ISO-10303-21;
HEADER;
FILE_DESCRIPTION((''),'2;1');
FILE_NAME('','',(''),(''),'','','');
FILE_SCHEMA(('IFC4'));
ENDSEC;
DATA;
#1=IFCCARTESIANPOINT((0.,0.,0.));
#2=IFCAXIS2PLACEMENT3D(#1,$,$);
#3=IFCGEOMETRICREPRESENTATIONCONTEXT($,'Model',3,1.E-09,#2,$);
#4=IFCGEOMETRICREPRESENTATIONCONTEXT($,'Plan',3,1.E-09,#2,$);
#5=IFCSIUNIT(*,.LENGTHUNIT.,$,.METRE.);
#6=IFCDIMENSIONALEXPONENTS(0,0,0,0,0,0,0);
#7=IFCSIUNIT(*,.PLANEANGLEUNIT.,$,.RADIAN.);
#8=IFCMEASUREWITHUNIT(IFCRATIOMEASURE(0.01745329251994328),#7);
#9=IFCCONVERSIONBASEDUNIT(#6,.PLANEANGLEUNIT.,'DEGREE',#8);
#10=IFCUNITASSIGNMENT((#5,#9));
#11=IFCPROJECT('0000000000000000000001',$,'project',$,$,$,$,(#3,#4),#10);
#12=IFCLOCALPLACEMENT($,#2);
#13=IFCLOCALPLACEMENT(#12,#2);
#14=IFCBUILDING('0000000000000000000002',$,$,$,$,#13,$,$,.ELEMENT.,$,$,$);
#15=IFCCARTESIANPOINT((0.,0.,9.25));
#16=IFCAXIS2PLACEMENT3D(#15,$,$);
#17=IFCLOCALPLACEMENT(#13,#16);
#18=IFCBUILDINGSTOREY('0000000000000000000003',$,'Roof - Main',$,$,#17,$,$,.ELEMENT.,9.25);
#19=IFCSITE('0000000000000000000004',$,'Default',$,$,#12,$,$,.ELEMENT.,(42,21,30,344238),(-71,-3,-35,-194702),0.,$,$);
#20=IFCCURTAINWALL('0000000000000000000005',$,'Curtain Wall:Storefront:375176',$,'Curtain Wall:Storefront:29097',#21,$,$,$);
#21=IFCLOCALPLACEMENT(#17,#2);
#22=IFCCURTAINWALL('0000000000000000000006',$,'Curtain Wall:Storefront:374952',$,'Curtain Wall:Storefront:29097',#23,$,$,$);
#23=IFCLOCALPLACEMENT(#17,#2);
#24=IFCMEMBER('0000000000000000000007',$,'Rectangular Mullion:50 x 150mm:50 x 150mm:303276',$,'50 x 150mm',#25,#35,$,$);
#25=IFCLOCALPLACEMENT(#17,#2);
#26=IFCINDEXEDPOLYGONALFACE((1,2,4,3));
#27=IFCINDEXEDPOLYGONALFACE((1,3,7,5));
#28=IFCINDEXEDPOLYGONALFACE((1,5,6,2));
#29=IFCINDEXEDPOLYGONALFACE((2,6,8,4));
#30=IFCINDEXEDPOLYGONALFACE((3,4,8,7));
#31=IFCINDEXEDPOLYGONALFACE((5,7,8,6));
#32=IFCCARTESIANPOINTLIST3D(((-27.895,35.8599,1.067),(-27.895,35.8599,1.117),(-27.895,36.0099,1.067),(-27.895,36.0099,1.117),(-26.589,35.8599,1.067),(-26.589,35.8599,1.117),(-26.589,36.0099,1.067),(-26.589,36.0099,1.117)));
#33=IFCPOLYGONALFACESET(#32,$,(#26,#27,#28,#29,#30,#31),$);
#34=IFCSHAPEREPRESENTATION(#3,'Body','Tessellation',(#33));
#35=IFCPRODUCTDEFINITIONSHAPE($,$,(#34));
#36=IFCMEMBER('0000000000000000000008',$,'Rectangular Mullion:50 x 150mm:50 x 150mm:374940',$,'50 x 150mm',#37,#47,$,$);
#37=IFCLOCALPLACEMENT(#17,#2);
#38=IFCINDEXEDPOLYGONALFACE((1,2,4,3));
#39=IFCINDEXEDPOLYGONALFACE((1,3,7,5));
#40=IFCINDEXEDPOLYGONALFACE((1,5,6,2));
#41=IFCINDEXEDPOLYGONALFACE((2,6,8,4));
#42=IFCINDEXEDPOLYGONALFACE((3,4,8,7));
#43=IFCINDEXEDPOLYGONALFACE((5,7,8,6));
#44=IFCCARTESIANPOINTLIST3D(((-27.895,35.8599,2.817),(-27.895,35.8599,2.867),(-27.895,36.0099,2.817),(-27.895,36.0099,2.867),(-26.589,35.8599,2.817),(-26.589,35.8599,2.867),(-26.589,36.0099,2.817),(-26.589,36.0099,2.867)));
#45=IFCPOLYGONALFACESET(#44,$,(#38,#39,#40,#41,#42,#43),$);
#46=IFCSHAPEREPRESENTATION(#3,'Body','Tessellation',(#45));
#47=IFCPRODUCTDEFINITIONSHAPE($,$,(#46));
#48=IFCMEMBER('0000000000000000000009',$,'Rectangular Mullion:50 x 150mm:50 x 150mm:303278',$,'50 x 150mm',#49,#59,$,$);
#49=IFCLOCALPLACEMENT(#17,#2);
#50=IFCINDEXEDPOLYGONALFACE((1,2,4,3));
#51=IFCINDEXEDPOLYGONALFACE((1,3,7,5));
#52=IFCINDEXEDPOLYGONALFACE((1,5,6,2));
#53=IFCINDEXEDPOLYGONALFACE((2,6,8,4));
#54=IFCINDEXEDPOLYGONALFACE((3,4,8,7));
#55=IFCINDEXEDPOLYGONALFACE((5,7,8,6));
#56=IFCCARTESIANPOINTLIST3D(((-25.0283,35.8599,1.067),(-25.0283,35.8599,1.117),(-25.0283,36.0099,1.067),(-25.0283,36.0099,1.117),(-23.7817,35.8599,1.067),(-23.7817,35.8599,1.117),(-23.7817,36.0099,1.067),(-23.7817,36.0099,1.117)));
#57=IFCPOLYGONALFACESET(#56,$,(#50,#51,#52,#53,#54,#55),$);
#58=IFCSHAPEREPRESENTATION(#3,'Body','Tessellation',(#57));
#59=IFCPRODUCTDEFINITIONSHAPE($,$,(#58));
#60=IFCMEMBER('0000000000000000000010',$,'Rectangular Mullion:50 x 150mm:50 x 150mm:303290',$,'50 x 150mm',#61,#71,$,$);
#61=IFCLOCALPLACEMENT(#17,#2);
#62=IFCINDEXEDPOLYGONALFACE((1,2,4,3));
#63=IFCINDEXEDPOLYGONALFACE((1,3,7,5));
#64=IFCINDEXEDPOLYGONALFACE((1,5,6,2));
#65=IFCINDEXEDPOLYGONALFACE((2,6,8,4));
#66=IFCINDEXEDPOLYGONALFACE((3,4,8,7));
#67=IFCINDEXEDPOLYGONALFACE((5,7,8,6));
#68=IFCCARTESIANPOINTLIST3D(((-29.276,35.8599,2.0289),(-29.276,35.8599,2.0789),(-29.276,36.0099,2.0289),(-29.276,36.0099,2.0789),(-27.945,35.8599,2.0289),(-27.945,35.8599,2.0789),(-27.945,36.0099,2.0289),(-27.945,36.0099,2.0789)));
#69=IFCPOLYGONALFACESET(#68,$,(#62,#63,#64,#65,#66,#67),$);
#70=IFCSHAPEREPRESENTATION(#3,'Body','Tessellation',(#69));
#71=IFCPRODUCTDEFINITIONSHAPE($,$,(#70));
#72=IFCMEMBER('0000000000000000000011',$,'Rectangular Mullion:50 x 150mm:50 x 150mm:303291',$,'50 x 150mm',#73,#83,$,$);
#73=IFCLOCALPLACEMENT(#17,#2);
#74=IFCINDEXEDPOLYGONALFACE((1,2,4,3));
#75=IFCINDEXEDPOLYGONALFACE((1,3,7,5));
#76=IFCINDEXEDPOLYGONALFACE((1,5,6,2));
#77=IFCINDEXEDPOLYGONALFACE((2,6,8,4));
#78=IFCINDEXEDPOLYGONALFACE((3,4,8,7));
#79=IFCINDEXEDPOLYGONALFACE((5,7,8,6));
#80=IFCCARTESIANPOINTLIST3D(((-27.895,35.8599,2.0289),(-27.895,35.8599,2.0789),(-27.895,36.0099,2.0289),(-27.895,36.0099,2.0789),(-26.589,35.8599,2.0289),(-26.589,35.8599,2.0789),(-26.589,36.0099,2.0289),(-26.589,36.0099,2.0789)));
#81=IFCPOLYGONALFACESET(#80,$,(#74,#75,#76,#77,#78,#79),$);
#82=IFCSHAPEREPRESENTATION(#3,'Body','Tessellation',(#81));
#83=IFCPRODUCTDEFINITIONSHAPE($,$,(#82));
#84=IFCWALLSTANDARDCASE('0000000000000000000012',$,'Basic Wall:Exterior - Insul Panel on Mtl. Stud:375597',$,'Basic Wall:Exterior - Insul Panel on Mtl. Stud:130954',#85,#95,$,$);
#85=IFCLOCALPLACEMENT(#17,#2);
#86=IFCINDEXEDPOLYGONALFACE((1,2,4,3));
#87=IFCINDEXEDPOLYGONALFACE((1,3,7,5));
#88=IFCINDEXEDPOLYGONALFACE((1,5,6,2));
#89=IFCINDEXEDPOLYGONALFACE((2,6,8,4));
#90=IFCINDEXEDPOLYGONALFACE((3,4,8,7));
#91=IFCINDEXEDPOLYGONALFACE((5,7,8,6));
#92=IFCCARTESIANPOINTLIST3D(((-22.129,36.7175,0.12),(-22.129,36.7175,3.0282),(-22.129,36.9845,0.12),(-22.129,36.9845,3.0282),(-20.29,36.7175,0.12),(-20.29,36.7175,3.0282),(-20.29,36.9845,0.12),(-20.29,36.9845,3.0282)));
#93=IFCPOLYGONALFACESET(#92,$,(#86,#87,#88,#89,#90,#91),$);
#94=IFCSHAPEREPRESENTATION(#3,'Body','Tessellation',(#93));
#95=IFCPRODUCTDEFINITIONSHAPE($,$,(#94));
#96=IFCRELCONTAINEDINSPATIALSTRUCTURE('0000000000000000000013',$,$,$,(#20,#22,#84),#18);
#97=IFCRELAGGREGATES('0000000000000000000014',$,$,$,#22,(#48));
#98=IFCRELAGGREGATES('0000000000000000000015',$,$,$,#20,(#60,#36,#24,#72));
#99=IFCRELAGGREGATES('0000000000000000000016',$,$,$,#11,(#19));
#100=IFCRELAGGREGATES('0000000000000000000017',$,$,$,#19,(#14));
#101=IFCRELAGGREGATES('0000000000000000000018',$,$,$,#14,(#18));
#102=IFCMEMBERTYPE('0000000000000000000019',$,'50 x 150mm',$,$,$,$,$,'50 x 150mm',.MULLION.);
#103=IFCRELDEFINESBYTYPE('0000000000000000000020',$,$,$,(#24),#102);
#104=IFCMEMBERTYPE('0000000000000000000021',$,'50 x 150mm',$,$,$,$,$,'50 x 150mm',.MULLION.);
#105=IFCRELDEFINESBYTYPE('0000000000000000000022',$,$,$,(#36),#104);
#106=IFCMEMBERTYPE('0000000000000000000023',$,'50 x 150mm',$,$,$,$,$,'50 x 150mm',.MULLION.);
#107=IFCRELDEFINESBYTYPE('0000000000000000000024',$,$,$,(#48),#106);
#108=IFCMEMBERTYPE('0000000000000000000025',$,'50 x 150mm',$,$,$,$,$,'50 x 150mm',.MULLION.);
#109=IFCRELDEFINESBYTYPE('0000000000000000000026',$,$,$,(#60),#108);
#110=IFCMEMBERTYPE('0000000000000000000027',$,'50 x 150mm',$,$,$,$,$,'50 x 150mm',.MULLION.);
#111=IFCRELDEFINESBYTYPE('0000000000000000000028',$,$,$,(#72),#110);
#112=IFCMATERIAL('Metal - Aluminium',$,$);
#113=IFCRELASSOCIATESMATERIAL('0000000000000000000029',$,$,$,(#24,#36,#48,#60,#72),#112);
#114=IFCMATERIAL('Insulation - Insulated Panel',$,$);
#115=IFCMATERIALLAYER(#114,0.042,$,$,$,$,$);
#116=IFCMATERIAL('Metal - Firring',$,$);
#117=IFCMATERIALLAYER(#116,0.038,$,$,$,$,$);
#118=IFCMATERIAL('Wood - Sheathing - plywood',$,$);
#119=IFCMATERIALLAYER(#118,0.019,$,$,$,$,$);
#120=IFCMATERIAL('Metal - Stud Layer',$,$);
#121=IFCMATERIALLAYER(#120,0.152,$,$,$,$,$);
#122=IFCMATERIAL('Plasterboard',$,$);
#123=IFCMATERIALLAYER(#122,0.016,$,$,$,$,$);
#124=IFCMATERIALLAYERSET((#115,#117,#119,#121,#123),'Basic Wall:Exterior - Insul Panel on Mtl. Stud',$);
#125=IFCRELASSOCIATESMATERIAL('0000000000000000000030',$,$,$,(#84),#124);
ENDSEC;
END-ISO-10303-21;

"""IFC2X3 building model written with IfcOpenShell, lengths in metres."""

from ifc_helpers import new_model, entity, si_unit, converted_unit, frame, frame_2d, origin, origin_2d_with_axis, place, context, project, spatial, rectangle, extrude, source, transform, mapped, material, layer, layer_set, layer_usage, type_object, type_shapes, element, aggregate, save


model = new_model("IFC2X3")

# Units and contexts
model_context = context("Model", 3, precision=1e-09, world=origin())
plan_context = context("Plan", 3, precision=1e-09, world=origin())
ifc_project = project(units=[si_unit("LENGTHUNIT", "METRE"), converted_unit("PLANEANGLEUNIT", "DEGREE", entity("IfcRatioMeasure", 0.01745329251994328), si_unit("PLANEANGLEUNIT", "RADIAN"), dimensions=[0, 0, 0, 0, 0, 0, 0])], contexts=[model_context, plan_context])

# Site, building, storey
site_placement = place(None, origin())
site = spatial("IfcSite", under=ifc_project, at=site_placement, Name="Default", CompositionType="ELEMENT", RefLatitude=(42, 21, 30, 344238), RefLongitude=(-71, -3, -35, -194702), RefElevation=0.0)
building_placement = place(site_placement, origin())
building = spatial("IfcBuilding", under=site, at=building_placement, CompositionType="ELEMENT")
storey_placement = place(building_placement, frame((0.0, 0.0, 9.25)))
storey = spatial("IfcBuildingStorey", under=building, at=storey_placement, Name="Roof - Main", CompositionType="ELEMENT", Elevation=9.25)

# Curtain walls
curtain_wall_1_placement = place(storey_placement, origin())
curtain_wall_1 = element("IfcCurtainWall", 1, at=curtain_wall_1_placement, inside=storey, Name="Curtain Wall:Storefront:375176", ObjectType="Curtain Wall:Storefront:29097")
ifc_material_1 = material(Name="Metal - Aluminium")
curtain_wall_2_placement = place(storey_placement, origin())
curtain_wall_2 = element("IfcCurtainWall", 2, at=curtain_wall_2_placement, inside=storey, Name="Curtain Wall:Storefront:374952", ObjectType="Curtain Wall:Storefront:29097")

# Members
member_type_1 = type_object("IfcMemberType", Name="50 x 150mm", ElementType="50 x 150mm", PredefinedType="MULLION")
shared_shape_1 = source(origin(), model_context, "Body", "SweptSolid", [
    extrude(rectangle(XDim=0.05, YDim=0.15, at=origin_2d_with_axis()), frame((-0.025, 0.0, -1.306), z_axis=(0.0, 0.0, 1.0), x_axis=(-1.0, 0.0, 0.0)), (0.0, 0.0, 1.0), 1.306),
])
type_shapes(member_type_1, [shared_shape_1])
member_1_placement = place(storey_placement, frame((-27.895, 35.9349, 1.067), z_axis=(-1.0, 0.0, 0.0), x_axis=(0.0, 0.0, -1.0)))
member_1 = element("IfcMember", 3, at=member_1_placement, type_object=member_type_1, material=ifc_material_1, Name="Rectangular Mullion:50 x 150mm:50 x 150mm:303276", ObjectType="50 x 150mm", context=model_context, shape_type="MappedRepresentation", body=[
    mapped(shared_shape_1, transform((0.0, 0.0, 0.0), scale=1.0)),
])
member_type_2 = type_object("IfcMemberType", Name="50 x 150mm", ElementType="50 x 150mm", PredefinedType="MULLION")
shared_shape_2 = source(origin(), model_context, "Body", "SweptSolid", [
    extrude(rectangle(XDim=0.05, YDim=0.15, at=origin_2d_with_axis()), frame((-0.025, 0.0, -1.306), z_axis=(0.0, 0.0, 1.0), x_axis=(-1.0, 0.0, 0.0)), (0.0, 0.0, 1.0), 1.306),
])
type_shapes(member_type_2, [shared_shape_2])
member_2_placement = place(storey_placement, frame((-26.589, 35.9349, 2.867), z_axis=(1.0, 0.0, 0.0), x_axis=(0.0, 0.0, 1.0)))
member_2 = element("IfcMember", 4, at=member_2_placement, type_object=member_type_2, material=ifc_material_1, Name="Rectangular Mullion:50 x 150mm:50 x 150mm:374940", ObjectType="50 x 150mm", context=model_context, shape_type="MappedRepresentation", body=[
    mapped(shared_shape_2, transform((0.0, 0.0, 0.0), scale=1.0)),
])
member_type_3 = type_object("IfcMemberType", Name="50 x 150mm", ElementType="50 x 150mm", PredefinedType="MULLION")
shared_shape_3 = source(origin(), model_context, "Body", "SweptSolid", [
    extrude(rectangle(XDim=0.05, YDim=0.15, at=origin_2d_with_axis()), frame((-0.025, 0.0, -1.2467), z_axis=(0.0, 0.0, 1.0), x_axis=(-1.0, 0.0, 0.0)), (0.0, 0.0, 1.0), 1.2467),
])
type_shapes(member_type_3, [shared_shape_3])
member_3_placement = place(storey_placement, frame((-25.0283, 35.9349, 1.067), z_axis=(-1.0, 0.0, 0.0), x_axis=(0.0, 0.0, -1.0)))
member_3 = element("IfcMember", 5, at=member_3_placement, type_object=member_type_3, material=ifc_material_1, Name="Rectangular Mullion:50 x 150mm:50 x 150mm:303278", ObjectType="50 x 150mm", context=model_context, shape_type="MappedRepresentation", body=[
    mapped(shared_shape_3, transform((0.0, 0.0, 0.0), scale=1.0)),
])
member_type_4 = type_object("IfcMemberType", Name="50 x 150mm", ElementType="50 x 150mm", PredefinedType="MULLION")
shared_shape_4 = source(origin(), model_context, "Body", "SweptSolid", [
    extrude(rectangle(XDim=0.05, YDim=0.15, at=origin_2d_with_axis()), frame((0.0, 0.0, -1.331), z_axis=(0.0, 0.0, 1.0), x_axis=(-1.0, 0.0, 0.0)), (0.0, 0.0, 1.0), 1.331),
])
type_shapes(member_type_4, [shared_shape_4])
member_4_placement = place(storey_placement, frame((-27.945, 35.9349, 2.0539), z_axis=(1.0, 0.0, 0.0), x_axis=(0.0, 0.0, 1.0)))
member_4 = element("IfcMember", 6, at=member_4_placement, type_object=member_type_4, material=ifc_material_1, Name="Rectangular Mullion:50 x 150mm:50 x 150mm:303290", ObjectType="50 x 150mm", context=model_context, shape_type="MappedRepresentation", body=[
    mapped(shared_shape_4, transform((0.0, 0.0, 0.0), scale=1.0)),
])
member_type_5 = type_object("IfcMemberType", Name="50 x 150mm", ElementType="50 x 150mm", PredefinedType="MULLION")
shared_shape_5 = source(origin(), model_context, "Body", "SweptSolid", [
    extrude(rectangle(XDim=0.05, YDim=0.15, at=origin_2d_with_axis()), frame((0.0, 0.0, -1.306), z_axis=(0.0, 0.0, 1.0), x_axis=(-1.0, 0.0, 0.0)), (0.0, 0.0, 1.0), 1.306),
])
type_shapes(member_type_5, [shared_shape_5])
member_5_placement = place(storey_placement, frame((-26.589, 35.9349, 2.0539), z_axis=(1.0, 0.0, 0.0), x_axis=(0.0, 0.0, 1.0)))
member_5 = element("IfcMember", 7, at=member_5_placement, type_object=member_type_5, material=ifc_material_1, Name="Rectangular Mullion:50 x 150mm:50 x 150mm:303291", ObjectType="50 x 150mm", context=model_context, shape_type="MappedRepresentation", body=[
    mapped(shared_shape_5, transform((0.0, 0.0, 0.0), scale=1.0)),
])

aggregate(curtain_wall_2, [member_3])
aggregate(curtain_wall_1, [member_4, member_2, member_1, member_5])

# Wall
ifc_material_2 = material(Name="Insulation - Insulated Panel")
ifc_layer_1 = layer(ifc_material_2, 0.042)
ifc_material_3 = material(Name="Metal - Firring")
ifc_layer_2 = layer(ifc_material_3, 0.038)
ifc_material_4 = material(Name="Wood - Sheathing - plywood")
ifc_layer_3 = layer(ifc_material_4, 0.019)
ifc_material_5 = material(Name="Metal - Stud Layer")
ifc_layer_4 = layer(ifc_material_5, 0.152)
ifc_material_6 = material(Name="Plasterboard")
ifc_layer_5 = layer(ifc_material_6, 0.016)
ifc_layer_set = layer_set([ifc_layer_1, ifc_layer_2, ifc_layer_3, ifc_layer_4, ifc_layer_5], Name="Basic Wall:Exterior - Insul Panel on Mtl. Stud")
ifc_layer_usage = layer_usage(ifc_layer_set, "AXIS2", "NEGATIVE", 0.1335)
wall_placement = place(storey_placement, frame((-22.129, 36.851, 0.12)))
element("IfcWallStandardCase", 8, at=wall_placement, inside=storey, material=ifc_layer_usage, Name="Basic Wall:Exterior - Insul Panel on Mtl. Stud:375597", ObjectType="Basic Wall:Exterior - Insul Panel on Mtl. Stud:130954", context=model_context, shape_type="SweptSolid", body=[
    extrude(rectangle(XDim=1.839, YDim=0.267, at=frame_2d((0.9195, 0.0), x_axis=(-1.0, 0.0))), origin(), (0.0, 0.0, 1.0), 2.9082),
])

save(model, "model.ifc")
